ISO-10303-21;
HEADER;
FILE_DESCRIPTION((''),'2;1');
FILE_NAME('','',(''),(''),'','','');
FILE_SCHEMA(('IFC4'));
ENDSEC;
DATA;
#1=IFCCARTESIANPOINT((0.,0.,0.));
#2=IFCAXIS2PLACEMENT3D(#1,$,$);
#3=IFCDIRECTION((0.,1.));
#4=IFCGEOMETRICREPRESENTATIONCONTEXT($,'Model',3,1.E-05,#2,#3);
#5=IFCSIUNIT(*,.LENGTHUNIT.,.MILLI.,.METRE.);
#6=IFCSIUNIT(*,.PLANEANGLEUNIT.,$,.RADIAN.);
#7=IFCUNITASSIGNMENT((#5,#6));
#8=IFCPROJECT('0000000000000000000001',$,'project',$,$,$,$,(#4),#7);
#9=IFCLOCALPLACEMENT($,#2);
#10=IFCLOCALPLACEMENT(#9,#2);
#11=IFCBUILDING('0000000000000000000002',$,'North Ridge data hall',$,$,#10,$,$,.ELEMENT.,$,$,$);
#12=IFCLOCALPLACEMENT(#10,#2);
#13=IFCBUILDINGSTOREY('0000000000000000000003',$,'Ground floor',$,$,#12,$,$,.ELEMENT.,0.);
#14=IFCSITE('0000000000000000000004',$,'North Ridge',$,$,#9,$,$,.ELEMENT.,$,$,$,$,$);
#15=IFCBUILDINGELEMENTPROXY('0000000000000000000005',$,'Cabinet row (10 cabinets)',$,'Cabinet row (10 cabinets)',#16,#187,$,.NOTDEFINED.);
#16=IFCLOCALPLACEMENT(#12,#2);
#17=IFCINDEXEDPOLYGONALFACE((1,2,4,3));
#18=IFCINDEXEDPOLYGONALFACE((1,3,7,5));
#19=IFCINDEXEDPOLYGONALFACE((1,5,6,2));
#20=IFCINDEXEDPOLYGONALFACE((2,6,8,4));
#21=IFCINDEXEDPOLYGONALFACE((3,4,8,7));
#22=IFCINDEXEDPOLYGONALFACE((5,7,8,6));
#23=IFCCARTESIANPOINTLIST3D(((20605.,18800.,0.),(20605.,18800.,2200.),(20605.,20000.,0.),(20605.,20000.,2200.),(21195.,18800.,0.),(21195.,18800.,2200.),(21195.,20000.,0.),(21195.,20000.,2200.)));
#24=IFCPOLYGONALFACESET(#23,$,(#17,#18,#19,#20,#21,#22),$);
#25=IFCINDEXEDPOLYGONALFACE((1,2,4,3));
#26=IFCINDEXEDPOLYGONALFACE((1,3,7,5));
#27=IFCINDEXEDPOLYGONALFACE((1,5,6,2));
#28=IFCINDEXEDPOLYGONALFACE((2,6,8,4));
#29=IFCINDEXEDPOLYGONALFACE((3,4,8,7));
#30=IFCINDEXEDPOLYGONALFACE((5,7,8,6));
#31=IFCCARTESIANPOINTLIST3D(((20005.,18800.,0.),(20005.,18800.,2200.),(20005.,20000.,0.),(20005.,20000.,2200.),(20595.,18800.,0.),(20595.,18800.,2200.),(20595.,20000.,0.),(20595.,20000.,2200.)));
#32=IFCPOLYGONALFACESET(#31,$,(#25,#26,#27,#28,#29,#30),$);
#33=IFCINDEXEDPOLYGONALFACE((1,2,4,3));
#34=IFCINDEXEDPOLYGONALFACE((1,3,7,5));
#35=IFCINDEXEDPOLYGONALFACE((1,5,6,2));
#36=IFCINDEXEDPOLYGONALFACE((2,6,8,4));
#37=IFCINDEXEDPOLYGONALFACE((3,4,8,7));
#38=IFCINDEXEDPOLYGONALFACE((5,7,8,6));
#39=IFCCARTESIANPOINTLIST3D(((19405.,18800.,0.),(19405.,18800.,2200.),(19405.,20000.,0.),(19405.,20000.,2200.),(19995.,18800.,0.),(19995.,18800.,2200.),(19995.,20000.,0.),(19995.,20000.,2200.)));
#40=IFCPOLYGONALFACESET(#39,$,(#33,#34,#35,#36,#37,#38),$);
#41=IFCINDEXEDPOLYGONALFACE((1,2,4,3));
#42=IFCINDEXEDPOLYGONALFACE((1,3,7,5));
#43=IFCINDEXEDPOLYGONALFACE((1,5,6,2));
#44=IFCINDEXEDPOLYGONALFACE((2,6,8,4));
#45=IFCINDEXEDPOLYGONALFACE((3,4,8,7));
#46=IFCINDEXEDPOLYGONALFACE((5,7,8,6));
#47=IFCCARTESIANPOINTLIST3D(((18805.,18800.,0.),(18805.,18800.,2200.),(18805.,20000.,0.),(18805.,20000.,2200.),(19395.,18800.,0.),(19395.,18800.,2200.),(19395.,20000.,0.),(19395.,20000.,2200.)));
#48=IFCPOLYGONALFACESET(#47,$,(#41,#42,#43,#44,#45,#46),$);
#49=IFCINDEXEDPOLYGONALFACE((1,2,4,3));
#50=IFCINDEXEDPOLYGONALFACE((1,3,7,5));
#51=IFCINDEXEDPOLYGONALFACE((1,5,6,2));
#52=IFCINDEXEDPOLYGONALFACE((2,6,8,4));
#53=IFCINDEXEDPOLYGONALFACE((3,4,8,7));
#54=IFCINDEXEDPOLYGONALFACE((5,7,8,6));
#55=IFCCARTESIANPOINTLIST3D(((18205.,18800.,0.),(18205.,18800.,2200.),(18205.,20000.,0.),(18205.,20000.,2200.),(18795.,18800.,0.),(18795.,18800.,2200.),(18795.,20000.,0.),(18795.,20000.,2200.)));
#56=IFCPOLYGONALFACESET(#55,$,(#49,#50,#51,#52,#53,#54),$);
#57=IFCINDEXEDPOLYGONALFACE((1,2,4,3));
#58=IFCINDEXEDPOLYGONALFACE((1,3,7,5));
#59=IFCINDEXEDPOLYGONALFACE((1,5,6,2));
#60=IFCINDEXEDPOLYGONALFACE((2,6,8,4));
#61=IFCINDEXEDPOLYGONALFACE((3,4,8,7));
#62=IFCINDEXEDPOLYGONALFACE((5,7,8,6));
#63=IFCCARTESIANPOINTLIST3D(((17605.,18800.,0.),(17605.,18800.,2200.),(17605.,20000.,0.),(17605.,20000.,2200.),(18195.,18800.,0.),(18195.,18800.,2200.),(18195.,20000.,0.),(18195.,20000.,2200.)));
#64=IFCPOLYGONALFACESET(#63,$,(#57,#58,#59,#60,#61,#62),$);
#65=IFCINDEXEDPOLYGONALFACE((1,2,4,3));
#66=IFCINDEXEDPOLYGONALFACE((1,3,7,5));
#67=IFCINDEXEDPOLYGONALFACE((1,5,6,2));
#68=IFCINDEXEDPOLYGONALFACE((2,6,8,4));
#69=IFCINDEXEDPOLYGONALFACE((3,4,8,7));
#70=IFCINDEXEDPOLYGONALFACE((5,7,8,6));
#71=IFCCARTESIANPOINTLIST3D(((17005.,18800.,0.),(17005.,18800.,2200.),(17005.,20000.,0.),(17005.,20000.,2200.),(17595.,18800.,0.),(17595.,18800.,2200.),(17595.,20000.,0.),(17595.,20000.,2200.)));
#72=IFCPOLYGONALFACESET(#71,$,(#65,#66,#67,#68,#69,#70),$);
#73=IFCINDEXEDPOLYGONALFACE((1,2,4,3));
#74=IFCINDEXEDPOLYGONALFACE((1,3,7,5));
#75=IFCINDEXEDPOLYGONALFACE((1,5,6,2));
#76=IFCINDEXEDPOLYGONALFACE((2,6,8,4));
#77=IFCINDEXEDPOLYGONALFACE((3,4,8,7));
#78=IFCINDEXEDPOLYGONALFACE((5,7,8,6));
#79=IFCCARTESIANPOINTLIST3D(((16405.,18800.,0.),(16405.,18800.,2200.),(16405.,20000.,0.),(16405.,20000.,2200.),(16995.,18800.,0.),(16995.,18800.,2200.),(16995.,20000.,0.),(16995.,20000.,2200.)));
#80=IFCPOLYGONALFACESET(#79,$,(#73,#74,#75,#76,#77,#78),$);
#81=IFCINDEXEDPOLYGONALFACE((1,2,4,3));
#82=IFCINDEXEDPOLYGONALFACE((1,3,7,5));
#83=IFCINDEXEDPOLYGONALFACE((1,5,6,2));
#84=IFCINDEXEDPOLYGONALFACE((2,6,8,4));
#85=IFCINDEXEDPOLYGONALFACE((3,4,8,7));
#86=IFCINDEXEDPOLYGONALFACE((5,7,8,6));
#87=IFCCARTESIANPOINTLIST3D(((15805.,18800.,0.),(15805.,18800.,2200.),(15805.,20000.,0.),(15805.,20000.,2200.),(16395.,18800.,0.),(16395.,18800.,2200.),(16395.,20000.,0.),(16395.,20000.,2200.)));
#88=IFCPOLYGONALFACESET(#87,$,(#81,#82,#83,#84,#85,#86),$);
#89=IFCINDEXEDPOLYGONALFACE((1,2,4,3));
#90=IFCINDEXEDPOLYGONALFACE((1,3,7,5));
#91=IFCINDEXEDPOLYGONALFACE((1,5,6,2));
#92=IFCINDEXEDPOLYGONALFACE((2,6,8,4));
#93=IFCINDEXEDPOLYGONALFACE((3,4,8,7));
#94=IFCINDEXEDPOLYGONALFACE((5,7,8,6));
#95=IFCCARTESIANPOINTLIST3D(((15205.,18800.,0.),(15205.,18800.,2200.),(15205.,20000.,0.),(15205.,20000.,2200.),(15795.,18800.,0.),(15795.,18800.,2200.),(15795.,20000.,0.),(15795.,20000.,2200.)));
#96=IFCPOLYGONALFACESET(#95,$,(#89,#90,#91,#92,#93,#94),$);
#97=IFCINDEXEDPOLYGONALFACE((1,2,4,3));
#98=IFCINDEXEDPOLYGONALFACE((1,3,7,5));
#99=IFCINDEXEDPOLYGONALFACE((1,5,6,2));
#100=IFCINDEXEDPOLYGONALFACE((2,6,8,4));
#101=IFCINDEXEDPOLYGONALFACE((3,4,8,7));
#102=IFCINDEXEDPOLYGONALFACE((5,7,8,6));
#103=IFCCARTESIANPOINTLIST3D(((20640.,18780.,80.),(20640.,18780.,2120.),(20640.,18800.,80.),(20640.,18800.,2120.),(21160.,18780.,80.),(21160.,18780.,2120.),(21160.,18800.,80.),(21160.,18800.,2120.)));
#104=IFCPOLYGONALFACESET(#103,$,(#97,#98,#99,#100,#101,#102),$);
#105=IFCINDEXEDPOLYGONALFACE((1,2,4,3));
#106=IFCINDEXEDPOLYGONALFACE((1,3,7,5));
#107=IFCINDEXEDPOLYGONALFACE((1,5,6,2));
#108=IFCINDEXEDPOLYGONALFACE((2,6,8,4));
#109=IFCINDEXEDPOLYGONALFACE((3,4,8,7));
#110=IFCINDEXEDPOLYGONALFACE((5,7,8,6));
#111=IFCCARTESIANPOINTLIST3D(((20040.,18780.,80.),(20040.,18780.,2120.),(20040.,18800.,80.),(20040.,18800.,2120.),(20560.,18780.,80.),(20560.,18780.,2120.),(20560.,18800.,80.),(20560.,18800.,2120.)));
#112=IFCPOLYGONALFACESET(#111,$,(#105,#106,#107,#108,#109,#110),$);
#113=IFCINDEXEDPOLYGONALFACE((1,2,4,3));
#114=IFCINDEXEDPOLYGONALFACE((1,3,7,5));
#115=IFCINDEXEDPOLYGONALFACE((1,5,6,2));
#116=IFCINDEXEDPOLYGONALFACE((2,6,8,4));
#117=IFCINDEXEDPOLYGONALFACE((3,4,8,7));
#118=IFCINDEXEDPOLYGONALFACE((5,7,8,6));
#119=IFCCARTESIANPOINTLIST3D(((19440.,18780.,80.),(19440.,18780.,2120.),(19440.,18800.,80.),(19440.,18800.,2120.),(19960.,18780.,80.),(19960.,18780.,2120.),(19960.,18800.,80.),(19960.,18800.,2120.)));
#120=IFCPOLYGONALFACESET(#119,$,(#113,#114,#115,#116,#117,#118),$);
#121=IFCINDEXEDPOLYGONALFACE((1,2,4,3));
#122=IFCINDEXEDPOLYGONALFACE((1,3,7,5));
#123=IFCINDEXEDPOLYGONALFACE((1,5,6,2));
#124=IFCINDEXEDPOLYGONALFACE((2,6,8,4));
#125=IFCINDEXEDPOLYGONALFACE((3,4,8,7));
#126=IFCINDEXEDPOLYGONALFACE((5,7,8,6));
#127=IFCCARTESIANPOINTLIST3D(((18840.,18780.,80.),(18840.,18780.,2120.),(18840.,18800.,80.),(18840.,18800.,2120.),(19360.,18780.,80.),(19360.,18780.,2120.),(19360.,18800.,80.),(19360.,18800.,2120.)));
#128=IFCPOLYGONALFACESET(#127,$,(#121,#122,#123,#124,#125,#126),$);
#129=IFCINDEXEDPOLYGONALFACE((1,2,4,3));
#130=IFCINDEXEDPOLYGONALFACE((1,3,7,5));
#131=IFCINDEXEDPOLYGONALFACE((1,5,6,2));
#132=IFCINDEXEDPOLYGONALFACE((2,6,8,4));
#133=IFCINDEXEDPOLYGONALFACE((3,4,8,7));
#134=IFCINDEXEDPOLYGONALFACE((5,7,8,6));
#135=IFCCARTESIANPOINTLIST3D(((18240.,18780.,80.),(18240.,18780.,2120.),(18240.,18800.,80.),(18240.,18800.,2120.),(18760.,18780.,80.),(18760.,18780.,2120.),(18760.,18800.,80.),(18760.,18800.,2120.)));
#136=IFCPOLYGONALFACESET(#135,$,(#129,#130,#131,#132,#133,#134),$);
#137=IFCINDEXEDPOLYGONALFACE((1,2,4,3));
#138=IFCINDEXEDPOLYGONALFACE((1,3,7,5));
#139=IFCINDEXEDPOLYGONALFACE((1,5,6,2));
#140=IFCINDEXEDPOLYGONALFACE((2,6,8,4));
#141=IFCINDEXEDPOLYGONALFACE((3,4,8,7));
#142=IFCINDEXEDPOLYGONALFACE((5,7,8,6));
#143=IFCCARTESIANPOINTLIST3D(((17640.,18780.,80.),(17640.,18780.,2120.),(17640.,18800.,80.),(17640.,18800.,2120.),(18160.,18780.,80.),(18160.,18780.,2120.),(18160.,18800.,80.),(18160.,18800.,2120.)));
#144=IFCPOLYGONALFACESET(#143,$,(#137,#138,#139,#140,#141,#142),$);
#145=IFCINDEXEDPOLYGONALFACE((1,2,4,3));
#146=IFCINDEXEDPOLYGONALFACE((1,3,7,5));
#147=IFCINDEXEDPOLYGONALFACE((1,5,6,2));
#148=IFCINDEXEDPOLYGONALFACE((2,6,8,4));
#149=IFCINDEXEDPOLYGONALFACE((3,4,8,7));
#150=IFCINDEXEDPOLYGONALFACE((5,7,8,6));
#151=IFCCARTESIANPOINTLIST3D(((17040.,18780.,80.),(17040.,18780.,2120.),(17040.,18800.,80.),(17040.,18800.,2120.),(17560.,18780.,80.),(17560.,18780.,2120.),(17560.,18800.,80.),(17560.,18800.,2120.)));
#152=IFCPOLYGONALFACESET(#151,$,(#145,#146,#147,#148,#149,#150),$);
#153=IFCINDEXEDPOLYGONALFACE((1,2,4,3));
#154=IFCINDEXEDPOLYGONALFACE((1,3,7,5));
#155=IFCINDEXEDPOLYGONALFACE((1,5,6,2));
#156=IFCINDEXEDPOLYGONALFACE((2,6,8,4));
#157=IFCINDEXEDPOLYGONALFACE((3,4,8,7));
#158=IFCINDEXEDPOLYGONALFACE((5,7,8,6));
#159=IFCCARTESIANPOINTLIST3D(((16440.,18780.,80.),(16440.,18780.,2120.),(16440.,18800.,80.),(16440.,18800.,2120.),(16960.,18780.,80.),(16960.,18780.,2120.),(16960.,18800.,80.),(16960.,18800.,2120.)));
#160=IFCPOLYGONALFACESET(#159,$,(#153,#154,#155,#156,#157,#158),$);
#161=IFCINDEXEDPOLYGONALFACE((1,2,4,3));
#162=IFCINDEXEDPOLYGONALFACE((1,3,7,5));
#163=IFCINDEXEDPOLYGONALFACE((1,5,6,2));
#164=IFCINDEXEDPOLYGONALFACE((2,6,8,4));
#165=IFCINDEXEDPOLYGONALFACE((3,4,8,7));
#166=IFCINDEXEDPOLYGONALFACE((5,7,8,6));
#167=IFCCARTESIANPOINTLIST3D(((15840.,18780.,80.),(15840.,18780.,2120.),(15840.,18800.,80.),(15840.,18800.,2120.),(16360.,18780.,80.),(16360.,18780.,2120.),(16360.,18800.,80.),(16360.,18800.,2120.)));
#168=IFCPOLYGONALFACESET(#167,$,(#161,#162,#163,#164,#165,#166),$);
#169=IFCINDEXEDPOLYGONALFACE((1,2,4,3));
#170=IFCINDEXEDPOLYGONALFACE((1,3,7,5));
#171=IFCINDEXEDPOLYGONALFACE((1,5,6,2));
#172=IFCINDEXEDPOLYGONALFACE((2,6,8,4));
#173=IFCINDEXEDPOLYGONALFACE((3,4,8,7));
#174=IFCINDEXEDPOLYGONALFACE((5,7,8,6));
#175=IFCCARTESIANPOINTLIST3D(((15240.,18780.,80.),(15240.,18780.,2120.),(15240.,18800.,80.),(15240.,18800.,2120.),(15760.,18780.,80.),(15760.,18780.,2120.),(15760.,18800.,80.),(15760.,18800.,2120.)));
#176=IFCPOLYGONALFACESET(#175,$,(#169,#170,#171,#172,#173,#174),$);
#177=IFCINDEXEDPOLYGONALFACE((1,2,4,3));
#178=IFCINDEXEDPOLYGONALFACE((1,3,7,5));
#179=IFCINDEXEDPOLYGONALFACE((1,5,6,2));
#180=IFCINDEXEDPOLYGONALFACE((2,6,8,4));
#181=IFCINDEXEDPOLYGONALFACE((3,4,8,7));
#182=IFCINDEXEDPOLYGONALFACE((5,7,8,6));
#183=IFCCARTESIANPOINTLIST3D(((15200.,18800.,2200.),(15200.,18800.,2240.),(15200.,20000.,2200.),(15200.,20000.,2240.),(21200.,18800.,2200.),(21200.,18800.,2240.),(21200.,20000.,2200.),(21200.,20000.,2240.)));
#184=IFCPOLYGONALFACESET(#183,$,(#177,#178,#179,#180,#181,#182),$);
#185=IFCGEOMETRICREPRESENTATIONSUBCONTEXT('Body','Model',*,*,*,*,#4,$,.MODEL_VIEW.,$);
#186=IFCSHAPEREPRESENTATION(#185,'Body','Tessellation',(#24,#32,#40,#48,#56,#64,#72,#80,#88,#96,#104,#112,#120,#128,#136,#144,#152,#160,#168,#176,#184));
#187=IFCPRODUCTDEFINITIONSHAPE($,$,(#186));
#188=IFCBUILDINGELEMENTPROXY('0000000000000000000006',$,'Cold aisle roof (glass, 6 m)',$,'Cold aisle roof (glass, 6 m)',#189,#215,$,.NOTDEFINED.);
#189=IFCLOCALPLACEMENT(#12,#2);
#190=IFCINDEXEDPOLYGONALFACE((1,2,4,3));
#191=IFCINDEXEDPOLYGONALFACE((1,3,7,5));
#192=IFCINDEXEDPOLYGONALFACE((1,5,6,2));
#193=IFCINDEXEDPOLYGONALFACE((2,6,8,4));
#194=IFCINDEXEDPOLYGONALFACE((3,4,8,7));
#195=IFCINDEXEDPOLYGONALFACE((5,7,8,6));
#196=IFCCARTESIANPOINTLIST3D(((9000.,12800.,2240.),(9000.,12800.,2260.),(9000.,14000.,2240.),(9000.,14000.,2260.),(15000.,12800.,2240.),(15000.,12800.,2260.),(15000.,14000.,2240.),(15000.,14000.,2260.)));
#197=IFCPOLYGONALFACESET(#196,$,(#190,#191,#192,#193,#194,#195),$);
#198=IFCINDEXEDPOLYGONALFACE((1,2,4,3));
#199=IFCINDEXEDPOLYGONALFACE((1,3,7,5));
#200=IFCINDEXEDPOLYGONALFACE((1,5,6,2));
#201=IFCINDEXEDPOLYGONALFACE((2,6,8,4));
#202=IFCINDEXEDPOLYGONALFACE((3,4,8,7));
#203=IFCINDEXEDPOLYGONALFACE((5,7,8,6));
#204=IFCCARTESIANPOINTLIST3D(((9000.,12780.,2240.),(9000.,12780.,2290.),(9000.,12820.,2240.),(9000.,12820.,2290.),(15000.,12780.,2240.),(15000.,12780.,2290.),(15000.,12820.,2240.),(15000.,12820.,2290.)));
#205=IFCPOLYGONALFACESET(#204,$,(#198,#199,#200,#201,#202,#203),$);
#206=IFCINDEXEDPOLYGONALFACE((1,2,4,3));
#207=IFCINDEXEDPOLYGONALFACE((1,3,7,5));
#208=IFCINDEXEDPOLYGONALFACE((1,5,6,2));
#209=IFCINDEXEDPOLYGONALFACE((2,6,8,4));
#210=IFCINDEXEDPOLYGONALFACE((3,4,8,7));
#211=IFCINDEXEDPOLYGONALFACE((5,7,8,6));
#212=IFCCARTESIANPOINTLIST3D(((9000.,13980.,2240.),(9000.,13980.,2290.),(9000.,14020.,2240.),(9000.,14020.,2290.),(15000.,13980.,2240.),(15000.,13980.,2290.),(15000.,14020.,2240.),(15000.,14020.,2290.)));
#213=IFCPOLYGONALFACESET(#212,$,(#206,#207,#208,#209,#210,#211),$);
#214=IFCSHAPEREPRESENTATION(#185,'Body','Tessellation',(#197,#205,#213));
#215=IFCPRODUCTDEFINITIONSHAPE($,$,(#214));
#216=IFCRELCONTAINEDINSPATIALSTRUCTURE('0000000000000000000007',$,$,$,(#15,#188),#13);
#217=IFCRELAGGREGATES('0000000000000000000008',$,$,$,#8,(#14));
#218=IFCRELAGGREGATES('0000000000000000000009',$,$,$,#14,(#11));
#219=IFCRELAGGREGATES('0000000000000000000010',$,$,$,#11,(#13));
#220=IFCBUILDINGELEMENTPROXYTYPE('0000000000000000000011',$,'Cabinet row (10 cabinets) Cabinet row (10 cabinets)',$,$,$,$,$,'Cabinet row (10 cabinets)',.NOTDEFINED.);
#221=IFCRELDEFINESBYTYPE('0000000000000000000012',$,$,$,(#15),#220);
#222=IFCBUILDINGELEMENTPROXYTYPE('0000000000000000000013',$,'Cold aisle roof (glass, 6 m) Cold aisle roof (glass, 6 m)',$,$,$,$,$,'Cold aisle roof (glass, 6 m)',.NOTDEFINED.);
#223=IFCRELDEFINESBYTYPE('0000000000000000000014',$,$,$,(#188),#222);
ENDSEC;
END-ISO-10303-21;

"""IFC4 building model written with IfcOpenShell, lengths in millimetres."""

from ifc_helpers import new_model, si_unit, direction, frame, origin, place, context, subcontext, project, spatial, polyline, outline, extrude, source, transform, mapped, type_object, type_shapes, element, save


model = new_model("IFC4")

# Units and contexts
model_context = context("Model", 3, precision=1e-05, world=origin(), true_north=direction((0.0, 1.0)))
body_context = subcontext(model_context, "Body", "Model", "MODEL_VIEW")
ifc_project = project(units=[si_unit("LENGTHUNIT", "METRE", prefix="MILLI"), si_unit("PLANEANGLEUNIT", "RADIAN")], contexts=[model_context])

# Site, building, storey
site_placement = place(None, origin())
site = spatial("IfcSite", under=ifc_project, at=site_placement, Name="North Ridge", CompositionType="ELEMENT")
building_placement = place(site_placement, origin())
building = spatial("IfcBuilding", under=site, at=building_placement, Name="North Ridge data hall", CompositionType="ELEMENT")
storey_placement = place(building_placement, origin())
storey = spatial("IfcBuildingStorey", under=building, at=storey_placement, Name="Ground floor", CompositionType="ELEMENT", Elevation=0.0)

# Building element proxies
building_element_proxy_type_1 = type_object("IfcBuildingElementProxyType", Name="Cabinet row (10 cabinets) Cabinet row (10 cabinets)", ElementType="Cabinet row (10 cabinets)", PredefinedType="NOTDEFINED")
shared_shape_1 = source(origin(), body_context, "Body", "SweptSolid", [
    extrude(outline(polyline([(5.0, 0.0), (595.0, 0.0), (595.0, 1200.0), (5.0, 1200.0), (5.0, 0.0)])), origin(), (0.0, 0.0, 1.0), 2200.0),
    extrude(outline(polyline([(605.0, 0.0), (1195.0, 0.0), (1195.0, 1200.0), (605.0, 1200.0), (605.0, 0.0)])), origin(), (0.0, 0.0, 1.0), 2200.0),
    extrude(outline(polyline([(1205.0, 0.0), (1795.0, 0.0), (1795.0, 1200.0), (1205.0, 1200.0), (1205.0, 0.0)])), origin(), (0.0, 0.0, 1.0), 2200.0),
    extrude(outline(polyline([(1805.0, 0.0), (2395.0, 0.0), (2395.0, 1200.0), (1805.0, 1200.0), (1805.0, 0.0)])), origin(), (0.0, 0.0, 1.0), 2200.0),
    extrude(outline(polyline([(2405.0, 0.0), (2995.0, 0.0), (2995.0, 1200.0), (2405.0, 1200.0), (2405.0, 0.0)])), origin(), (0.0, 0.0, 1.0), 2200.0),
    extrude(outline(polyline([(3005.0, 0.0), (3595.0, 0.0), (3595.0, 1200.0), (3005.0, 1200.0), (3005.0, 0.0)])), origin(), (0.0, 0.0, 1.0), 2200.0),
    extrude(outline(polyline([(3605.0, 0.0), (4195.0, 0.0), (4195.0, 1200.0), (3605.0, 1200.0), (3605.0, 0.0)])), origin(), (0.0, 0.0, 1.0), 2200.0),
    extrude(outline(polyline([(4205.0, 0.0), (4795.0, 0.0), (4795.0, 1200.0), (4205.0, 1200.0), (4205.0, 0.0)])), origin(), (0.0, 0.0, 1.0), 2200.0),
    extrude(outline(polyline([(4805.0, 0.0), (5395.0, 0.0), (5395.0, 1200.0), (4805.0, 1200.0), (4805.0, 0.0)])), origin(), (0.0, 0.0, 1.0), 2200.0),
    extrude(outline(polyline([(5405.0, 0.0), (5995.0, 0.0), (5995.0, 1200.0), (5405.0, 1200.0), (5405.0, 0.0)])), origin(), (0.0, 0.0, 1.0), 2200.0),
    extrude(outline(polyline([(40.0, 1200.0), (560.0, 1200.0), (560.0, 1220.0), (40.0, 1220.0), (40.0, 1200.0)])), frame((0.0, 0.0, 80.0)), (0.0, 0.0, 1.0), 2040.0),
    extrude(outline(polyline([(640.0, 1200.0), (1160.0, 1200.0), (1160.0, 1220.0), (640.0, 1220.0), (640.0, 1200.0)])), frame((0.0, 0.0, 80.0)), (0.0, 0.0, 1.0), 2040.0),
    extrude(outline(polyline([(1240.0, 1200.0), (1760.0, 1200.0), (1760.0, 1220.0), (1240.0, 1220.0), (1240.0, 1200.0)])), frame((0.0, 0.0, 80.0)), (0.0, 0.0, 1.0), 2040.0),
    extrude(outline(polyline([(1840.0, 1200.0), (2360.0, 1200.0), (2360.0, 1220.0), (1840.0, 1220.0), (1840.0, 1200.0)])), frame((0.0, 0.0, 80.0)), (0.0, 0.0, 1.0), 2040.0),
    extrude(outline(polyline([(2440.0, 1200.0), (2960.0, 1200.0), (2960.0, 1220.0), (2440.0, 1220.0), (2440.0, 1200.0)])), frame((0.0, 0.0, 80.0)), (0.0, 0.0, 1.0), 2040.0),
    extrude(outline(polyline([(3040.0, 1200.0), (3560.0, 1200.0), (3560.0, 1220.0), (3040.0, 1220.0), (3040.0, 1200.0)])), frame((0.0, 0.0, 80.0)), (0.0, 0.0, 1.0), 2040.0),
    extrude(outline(polyline([(3640.0, 1200.0), (4160.0, 1200.0), (4160.0, 1220.0), (3640.0, 1220.0), (3640.0, 1200.0)])), frame((0.0, 0.0, 80.0)), (0.0, 0.0, 1.0), 2040.0),
    extrude(outline(polyline([(4240.0, 1200.0), (4760.0, 1200.0), (4760.0, 1220.0), (4240.0, 1220.0), (4240.0, 1200.0)])), frame((0.0, 0.0, 80.0)), (0.0, 0.0, 1.0), 2040.0),
    extrude(outline(polyline([(4840.0, 1200.0), (5360.0, 1200.0), (5360.0, 1220.0), (4840.0, 1220.0), (4840.0, 1200.0)])), frame((0.0, 0.0, 80.0)), (0.0, 0.0, 1.0), 2040.0),
    extrude(outline(polyline([(5440.0, 1200.0), (5960.0, 1200.0), (5960.0, 1220.0), (5440.0, 1220.0), (5440.0, 1200.0)])), frame((0.0, 0.0, 80.0)), (0.0, 0.0, 1.0), 2040.0),
    extrude(outline(polyline([(0.0, 0.0), (6000.0, 0.0), (6000.0, 1200.0), (0.0, 1200.0), (0.0, 0.0)])), frame((0.0, 0.0, 2200.0)), (0.0, 0.0, 1.0), 40.0),
])
type_shapes(building_element_proxy_type_1, [shared_shape_1])
for number, where, z_axis, x_axis, name in (
    (1, (21200.0, 20000.0, 0.0), (0.0, 0.0, 1.0), (-1.0, 0.0, 0.0), "Cabinet row (10 cabinets)"),
):
    element("IfcBuildingElementProxy", number, at=place(storey_placement, frame(where, z_axis=z_axis, x_axis=x_axis)), inside=storey, type_object=building_element_proxy_type_1, Name=name, ObjectType="Cabinet row (10 cabinets)", PredefinedType="NOTDEFINED", context=body_context, shape_type="MappedRepresentation", body=[
        mapped(shared_shape_1, transform((0.0, 0.0, 0.0))),
    ])
building_element_proxy_type_2 = type_object("IfcBuildingElementProxyType", Name="Cold aisle roof (glass, 6 m) Cold aisle roof (glass, 6 m)", ElementType="Cold aisle roof (glass, 6 m)", PredefinedType="NOTDEFINED")
shared_shape_2 = source(origin(), body_context, "Body", "SweptSolid", [
    extrude(outline(polyline([(0.0, 0.0), (6000.0, 0.0), (6000.0, 1200.0), (0.0, 1200.0), (0.0, 0.0)])), frame((0.0, 0.0, 2240.0)), (0.0, 0.0, 1.0), 20.0),
    extrude(outline(polyline([(0.0, -20.0), (6000.0, -20.0), (6000.0, 20.0), (0.0, 20.0), (0.0, -20.0)])), frame((0.0, 0.0, 2240.0)), (0.0, 0.0, 1.0), 50.0),
    extrude(outline(polyline([(0.0, 1180.0), (6000.0, 1180.0), (6000.0, 1220.0), (0.0, 1220.0), (0.0, 1180.0)])), frame((0.0, 0.0, 2240.0)), (0.0, 0.0, 1.0), 50.0),
])
type_shapes(building_element_proxy_type_2, [shared_shape_2])
for number, where, z_axis, x_axis, name in (
    (2, (9000.0, 12800.0, 0.0), (0.0, 0.0, 1.0), (1.0, 0.0, 0.0), "Cold aisle roof (glass, 6 m)"),
):
    element("IfcBuildingElementProxy", number, at=place(storey_placement, frame(where, z_axis=z_axis, x_axis=x_axis)), inside=storey, type_object=building_element_proxy_type_2, Name=name, ObjectType="Cold aisle roof (glass, 6 m)", PredefinedType="NOTDEFINED", context=body_context, shape_type="MappedRepresentation", body=[
        mapped(shared_shape_2, transform((0.0, 0.0, 0.0))),
    ])

save(model, "model.ifc")
